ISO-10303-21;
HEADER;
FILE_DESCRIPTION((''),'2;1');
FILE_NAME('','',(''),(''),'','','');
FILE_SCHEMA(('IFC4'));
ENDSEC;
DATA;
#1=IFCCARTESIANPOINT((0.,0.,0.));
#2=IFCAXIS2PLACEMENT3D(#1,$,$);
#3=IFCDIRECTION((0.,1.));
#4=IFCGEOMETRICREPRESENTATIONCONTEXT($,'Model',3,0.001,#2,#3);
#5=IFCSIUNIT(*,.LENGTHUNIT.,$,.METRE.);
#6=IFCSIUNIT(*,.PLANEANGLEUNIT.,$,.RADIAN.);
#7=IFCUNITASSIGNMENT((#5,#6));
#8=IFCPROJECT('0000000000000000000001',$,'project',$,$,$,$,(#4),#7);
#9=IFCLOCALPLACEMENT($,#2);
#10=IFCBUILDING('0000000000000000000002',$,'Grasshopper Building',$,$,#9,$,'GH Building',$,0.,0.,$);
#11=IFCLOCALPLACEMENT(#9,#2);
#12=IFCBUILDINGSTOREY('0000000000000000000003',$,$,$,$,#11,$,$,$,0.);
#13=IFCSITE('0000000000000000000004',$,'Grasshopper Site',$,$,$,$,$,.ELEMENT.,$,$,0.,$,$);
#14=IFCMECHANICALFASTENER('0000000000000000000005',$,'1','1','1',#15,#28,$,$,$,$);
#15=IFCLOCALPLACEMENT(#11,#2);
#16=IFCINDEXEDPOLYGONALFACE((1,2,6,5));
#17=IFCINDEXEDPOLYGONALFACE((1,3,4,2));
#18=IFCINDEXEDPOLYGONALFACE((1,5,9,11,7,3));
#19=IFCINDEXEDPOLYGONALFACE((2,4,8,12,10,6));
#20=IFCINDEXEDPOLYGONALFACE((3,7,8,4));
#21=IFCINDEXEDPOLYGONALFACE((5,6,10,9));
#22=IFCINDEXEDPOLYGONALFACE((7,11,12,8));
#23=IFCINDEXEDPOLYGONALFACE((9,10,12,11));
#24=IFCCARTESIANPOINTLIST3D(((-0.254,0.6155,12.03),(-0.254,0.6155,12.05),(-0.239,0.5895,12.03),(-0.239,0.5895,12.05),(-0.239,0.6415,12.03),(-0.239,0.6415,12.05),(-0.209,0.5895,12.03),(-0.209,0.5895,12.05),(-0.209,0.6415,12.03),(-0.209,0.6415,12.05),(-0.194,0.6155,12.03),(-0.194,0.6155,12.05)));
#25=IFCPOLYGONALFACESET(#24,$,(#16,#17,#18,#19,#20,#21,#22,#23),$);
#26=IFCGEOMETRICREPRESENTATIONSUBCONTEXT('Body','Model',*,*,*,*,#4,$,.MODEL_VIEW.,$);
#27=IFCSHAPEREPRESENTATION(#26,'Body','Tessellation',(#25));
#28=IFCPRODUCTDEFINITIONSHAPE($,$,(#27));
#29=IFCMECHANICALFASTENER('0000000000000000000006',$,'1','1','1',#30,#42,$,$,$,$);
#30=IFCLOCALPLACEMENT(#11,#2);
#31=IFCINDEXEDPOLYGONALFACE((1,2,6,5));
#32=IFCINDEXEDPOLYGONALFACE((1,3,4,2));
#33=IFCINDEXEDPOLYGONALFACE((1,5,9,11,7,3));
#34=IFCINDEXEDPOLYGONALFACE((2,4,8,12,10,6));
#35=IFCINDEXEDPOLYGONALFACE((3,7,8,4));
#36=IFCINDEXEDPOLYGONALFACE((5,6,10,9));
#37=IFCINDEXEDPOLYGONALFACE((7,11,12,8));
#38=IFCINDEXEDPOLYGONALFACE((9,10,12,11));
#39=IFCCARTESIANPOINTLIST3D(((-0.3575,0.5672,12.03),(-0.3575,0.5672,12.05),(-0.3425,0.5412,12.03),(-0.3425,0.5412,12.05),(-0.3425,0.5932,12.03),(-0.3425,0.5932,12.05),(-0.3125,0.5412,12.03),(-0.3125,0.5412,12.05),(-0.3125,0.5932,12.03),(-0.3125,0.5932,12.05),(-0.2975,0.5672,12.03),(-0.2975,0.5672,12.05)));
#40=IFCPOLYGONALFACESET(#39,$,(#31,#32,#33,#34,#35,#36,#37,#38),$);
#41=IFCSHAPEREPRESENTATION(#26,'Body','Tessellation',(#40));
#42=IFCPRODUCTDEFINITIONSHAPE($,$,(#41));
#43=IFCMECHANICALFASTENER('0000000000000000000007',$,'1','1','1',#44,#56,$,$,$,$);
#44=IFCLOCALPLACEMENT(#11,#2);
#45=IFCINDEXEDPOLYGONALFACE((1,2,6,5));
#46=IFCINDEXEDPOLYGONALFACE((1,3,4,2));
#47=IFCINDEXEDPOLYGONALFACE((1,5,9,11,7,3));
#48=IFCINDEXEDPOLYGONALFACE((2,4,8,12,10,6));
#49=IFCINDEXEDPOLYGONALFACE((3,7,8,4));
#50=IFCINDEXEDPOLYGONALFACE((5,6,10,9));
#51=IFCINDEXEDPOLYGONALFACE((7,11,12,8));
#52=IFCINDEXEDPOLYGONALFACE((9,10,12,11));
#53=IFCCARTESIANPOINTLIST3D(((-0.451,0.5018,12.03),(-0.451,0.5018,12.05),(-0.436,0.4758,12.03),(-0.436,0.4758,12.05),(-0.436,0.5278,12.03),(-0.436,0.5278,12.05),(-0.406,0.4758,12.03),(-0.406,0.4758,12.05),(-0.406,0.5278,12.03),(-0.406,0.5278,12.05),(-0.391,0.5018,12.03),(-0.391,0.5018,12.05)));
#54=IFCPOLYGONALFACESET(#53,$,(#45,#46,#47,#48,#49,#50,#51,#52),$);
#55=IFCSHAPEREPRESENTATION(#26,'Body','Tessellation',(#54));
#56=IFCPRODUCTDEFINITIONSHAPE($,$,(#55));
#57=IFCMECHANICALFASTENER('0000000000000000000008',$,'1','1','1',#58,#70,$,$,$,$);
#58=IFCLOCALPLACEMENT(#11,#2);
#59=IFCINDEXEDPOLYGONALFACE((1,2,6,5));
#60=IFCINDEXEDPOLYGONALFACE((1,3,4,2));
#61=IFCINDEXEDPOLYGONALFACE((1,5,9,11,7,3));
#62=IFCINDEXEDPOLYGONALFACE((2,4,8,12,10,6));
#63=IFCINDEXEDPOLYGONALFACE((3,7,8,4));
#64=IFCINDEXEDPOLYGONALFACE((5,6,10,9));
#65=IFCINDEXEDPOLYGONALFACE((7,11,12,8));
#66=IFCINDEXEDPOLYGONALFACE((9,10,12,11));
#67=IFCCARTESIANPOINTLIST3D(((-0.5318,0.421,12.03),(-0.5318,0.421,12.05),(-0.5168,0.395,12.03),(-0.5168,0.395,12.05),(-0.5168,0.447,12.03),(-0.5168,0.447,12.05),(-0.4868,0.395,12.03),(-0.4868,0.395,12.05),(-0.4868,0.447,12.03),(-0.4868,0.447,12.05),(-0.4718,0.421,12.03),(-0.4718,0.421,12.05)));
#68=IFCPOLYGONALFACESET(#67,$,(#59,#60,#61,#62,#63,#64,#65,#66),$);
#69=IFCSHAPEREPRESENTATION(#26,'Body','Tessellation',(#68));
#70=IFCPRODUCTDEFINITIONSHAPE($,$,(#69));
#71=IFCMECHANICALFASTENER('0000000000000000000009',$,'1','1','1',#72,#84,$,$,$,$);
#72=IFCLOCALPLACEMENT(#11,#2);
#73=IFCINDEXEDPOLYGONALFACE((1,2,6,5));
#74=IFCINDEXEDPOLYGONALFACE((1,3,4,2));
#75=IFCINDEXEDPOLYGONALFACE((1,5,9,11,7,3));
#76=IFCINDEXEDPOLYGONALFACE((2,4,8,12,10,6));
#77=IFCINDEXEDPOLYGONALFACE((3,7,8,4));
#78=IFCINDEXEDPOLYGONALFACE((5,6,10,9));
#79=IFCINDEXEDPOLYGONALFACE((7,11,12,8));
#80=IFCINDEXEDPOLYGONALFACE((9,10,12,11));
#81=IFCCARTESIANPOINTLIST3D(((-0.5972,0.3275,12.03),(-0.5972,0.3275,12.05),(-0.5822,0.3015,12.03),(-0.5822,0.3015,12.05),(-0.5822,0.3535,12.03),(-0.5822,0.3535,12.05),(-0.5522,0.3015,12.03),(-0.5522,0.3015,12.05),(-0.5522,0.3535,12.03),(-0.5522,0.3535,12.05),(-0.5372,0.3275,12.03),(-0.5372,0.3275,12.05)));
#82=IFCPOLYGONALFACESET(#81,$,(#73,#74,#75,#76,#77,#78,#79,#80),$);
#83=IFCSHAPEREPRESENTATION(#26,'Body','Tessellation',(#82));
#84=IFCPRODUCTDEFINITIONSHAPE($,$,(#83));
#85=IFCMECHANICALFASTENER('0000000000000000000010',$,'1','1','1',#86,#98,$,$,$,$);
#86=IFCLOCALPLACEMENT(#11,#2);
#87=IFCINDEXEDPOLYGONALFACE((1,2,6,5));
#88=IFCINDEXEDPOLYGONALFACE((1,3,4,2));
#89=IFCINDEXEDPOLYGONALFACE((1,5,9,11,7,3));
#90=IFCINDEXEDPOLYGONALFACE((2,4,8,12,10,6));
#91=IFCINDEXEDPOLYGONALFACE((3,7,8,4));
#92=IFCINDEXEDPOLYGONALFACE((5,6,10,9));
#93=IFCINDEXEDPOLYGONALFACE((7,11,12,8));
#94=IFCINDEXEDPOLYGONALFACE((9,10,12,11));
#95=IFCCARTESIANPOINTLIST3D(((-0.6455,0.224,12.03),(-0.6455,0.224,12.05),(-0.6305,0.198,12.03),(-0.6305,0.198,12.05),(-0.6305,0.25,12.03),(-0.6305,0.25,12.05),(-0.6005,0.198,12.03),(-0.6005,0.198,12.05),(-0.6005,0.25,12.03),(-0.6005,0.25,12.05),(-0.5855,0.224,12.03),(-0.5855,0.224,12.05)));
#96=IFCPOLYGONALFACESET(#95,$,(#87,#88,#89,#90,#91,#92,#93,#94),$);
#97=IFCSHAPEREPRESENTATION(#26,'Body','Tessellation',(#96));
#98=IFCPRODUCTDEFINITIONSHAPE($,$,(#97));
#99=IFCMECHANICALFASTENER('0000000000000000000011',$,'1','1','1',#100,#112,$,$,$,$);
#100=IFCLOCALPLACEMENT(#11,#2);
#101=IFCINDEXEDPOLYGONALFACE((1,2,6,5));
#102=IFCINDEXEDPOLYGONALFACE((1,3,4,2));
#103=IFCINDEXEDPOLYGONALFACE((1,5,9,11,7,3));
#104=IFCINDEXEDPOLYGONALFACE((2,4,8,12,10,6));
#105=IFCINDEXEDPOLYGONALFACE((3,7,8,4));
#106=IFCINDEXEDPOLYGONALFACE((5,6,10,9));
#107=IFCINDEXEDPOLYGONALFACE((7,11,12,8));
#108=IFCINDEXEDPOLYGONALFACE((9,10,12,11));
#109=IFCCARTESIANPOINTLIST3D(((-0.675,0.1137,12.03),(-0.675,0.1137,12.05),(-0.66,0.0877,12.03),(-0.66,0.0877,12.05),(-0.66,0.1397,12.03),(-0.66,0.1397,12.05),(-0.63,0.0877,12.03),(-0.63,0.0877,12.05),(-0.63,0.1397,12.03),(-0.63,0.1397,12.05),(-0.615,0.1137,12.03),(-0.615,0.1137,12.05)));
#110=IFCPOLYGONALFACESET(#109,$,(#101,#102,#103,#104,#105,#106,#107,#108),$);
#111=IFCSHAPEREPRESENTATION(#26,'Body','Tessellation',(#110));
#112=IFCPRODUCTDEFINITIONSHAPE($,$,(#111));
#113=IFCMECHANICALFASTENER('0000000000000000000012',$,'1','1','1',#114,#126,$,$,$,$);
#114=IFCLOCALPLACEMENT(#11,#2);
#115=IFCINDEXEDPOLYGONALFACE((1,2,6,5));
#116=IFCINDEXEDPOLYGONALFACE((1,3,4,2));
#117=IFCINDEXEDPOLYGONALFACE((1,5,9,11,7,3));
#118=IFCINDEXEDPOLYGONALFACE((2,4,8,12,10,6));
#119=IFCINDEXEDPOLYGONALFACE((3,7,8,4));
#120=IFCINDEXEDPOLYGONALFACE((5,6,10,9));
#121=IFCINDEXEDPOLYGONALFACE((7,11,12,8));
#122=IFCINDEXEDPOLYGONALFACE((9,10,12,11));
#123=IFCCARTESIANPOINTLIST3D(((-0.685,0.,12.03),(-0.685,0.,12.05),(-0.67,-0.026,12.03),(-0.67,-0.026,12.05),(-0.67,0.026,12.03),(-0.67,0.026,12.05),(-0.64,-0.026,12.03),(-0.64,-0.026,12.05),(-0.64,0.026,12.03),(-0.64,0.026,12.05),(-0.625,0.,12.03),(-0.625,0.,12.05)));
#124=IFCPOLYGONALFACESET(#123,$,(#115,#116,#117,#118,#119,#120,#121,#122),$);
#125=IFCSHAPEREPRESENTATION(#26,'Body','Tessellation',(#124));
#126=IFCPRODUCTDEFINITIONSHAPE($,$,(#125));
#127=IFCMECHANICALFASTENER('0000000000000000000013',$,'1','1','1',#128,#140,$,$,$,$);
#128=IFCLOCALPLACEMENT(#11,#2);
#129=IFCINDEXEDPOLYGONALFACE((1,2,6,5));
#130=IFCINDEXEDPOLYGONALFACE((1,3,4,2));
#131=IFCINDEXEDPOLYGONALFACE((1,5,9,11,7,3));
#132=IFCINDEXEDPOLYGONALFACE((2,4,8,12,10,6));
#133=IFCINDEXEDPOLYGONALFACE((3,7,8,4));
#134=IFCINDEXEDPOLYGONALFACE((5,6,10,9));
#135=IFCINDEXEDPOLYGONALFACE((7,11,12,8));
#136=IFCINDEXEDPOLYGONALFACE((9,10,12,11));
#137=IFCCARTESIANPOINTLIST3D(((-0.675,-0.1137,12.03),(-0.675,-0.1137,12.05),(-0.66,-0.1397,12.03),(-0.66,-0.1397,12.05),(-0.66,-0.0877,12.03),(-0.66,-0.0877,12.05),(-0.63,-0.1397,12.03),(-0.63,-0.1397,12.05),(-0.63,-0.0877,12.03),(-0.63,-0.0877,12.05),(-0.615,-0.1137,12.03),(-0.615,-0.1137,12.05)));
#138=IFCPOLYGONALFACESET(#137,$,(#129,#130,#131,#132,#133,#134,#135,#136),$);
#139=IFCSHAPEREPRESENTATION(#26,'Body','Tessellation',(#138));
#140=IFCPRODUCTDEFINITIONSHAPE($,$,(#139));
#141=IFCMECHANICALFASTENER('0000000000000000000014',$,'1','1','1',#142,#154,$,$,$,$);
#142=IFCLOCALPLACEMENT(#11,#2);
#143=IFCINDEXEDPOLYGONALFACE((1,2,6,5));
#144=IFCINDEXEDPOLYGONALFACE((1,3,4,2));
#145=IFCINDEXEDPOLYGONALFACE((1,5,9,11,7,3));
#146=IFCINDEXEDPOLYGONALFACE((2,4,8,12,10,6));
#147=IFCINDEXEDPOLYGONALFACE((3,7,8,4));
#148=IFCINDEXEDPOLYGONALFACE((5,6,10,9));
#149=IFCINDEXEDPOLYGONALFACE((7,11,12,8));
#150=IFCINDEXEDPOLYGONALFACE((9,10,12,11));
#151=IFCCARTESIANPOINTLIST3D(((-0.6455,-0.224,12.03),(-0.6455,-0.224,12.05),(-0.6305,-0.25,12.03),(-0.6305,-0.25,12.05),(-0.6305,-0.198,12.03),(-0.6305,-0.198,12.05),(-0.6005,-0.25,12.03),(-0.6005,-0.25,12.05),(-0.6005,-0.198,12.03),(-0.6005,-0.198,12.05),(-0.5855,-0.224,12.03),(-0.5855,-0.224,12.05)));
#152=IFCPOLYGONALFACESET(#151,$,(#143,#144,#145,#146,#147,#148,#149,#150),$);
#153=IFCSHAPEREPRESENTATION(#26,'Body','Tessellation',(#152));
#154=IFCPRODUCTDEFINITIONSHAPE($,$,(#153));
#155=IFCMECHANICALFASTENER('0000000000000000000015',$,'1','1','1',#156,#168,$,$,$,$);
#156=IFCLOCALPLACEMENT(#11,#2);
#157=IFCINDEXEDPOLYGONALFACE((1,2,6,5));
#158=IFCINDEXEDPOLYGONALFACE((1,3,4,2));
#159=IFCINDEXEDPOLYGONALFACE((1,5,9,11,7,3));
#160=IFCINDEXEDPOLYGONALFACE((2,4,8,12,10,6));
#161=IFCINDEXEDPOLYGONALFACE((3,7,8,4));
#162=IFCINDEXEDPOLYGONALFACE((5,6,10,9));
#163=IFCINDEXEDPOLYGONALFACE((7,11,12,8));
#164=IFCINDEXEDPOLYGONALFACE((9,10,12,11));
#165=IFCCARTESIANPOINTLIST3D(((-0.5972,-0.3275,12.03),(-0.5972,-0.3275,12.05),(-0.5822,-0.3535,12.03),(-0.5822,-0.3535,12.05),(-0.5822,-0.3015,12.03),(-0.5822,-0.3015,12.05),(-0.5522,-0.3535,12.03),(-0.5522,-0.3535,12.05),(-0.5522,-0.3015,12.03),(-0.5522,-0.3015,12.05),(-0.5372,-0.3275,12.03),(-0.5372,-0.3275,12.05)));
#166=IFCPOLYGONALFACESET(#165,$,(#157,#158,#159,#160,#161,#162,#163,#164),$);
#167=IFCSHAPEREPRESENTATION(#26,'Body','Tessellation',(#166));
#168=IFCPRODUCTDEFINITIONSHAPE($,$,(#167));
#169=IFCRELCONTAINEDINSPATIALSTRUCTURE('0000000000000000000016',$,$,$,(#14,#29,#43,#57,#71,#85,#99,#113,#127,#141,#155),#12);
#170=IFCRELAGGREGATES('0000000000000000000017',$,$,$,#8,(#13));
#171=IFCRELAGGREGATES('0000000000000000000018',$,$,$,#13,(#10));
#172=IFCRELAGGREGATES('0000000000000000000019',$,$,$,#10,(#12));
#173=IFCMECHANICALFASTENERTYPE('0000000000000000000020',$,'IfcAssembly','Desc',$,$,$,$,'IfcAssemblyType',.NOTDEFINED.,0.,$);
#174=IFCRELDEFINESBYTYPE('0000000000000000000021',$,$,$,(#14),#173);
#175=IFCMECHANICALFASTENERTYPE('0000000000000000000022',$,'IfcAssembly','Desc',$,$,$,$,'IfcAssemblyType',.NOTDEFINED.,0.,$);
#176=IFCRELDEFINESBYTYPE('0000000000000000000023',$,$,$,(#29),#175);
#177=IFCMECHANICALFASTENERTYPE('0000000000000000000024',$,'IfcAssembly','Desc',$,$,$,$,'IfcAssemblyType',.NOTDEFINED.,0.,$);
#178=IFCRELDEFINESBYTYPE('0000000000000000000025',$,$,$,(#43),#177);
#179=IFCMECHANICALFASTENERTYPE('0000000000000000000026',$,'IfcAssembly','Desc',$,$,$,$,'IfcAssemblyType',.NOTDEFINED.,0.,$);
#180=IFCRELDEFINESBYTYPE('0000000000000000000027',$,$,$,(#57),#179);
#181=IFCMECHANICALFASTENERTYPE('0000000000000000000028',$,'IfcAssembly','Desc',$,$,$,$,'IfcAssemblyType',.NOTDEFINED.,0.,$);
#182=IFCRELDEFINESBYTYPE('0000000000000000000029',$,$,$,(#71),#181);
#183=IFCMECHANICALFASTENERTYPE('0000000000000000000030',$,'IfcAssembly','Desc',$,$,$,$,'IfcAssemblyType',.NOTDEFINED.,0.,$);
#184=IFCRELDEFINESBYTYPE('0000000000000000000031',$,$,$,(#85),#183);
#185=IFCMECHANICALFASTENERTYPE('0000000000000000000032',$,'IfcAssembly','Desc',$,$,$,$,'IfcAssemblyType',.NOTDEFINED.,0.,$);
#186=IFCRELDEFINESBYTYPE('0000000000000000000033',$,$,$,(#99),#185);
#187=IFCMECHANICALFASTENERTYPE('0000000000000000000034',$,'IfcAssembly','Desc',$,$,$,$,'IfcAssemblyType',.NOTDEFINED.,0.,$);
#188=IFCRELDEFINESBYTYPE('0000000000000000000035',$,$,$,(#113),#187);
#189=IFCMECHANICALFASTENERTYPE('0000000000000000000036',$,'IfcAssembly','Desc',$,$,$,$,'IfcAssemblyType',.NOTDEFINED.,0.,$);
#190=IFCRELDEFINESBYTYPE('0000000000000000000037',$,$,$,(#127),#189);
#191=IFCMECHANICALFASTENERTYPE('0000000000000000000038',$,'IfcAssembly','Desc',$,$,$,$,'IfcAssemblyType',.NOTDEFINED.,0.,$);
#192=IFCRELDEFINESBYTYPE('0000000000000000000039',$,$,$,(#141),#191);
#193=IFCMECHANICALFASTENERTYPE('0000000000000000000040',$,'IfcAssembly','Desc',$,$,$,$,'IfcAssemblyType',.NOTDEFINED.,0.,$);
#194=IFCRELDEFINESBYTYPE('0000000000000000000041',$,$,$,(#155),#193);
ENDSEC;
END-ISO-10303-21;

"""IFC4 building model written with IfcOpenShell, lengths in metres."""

from ifc_helpers import new_model, si_unit, direction, frame, origin, place, context, subcontext, project, spatial, indexed_curve, outline, extrude, source, transform, mapped, type_object, type_shapes, element, save


model = new_model("IFC4")

# Units and contexts
model_context = context("Model", 3, precision=0.001, world=origin(), true_north=direction((0.0, 1.0)))
body_context = subcontext(model_context, "Body", "Model", "MODEL_VIEW")
ifc_project = project(units=[si_unit("LENGTHUNIT", "METRE"), si_unit("PLANEANGLEUNIT", "RADIAN")], contexts=[model_context])

# Site, building, storey
site = spatial("IfcSite", under=ifc_project, Name="Grasshopper Site", CompositionType="ELEMENT", RefElevation=0.0)
building_placement = place(None, origin())
building = spatial("IfcBuilding", under=site, at=building_placement, Name="Grasshopper Building", LongName="GH Building", ElevationOfRefHeight=0.0, ElevationOfTerrain=0.0)
storey_placement = place(building_placement, origin())
storey = spatial("IfcBuildingStorey", under=building, at=storey_placement, Elevation=0.0)

# Mechanical fasteners
mechanical_fastener_type_1 = type_object("IfcMechanicalFastenerType", Name="IfcAssembly", Description="Desc", ElementType="IfcAssemblyType", NominalDiameter=0.0)
shared_shape_1 = source(origin(), body_context, "Body", "SweptSolid", [
    extrude(outline(indexed_curve([(0.03, 0.0), (0.015, 0.026), (-0.015, 0.026), (-0.03, 0.0), (-0.015, -0.026), (0.015, -0.026), (0.03, 0.0)])), frame((-0.224, 0.6155, 12.03)), (0.0, 0.0, 1.0), 0.02),
])
type_shapes(mechanical_fastener_type_1, [shared_shape_1])
mechanical_fastener_1_placement = place(storey_placement, origin())
element("IfcMechanicalFastener", 1, at=mechanical_fastener_1_placement, inside=storey, type_object=mechanical_fastener_type_1, Name="1", Description="1", ObjectType="1", context=body_context, shape_type="MappedRepresentation", body=[
    mapped(shared_shape_1, transform((0.0, 0.0, 0.0), scale=1.0)),
])
mechanical_fastener_type_2 = type_object("IfcMechanicalFastenerType", Name="IfcAssembly", Description="Desc", ElementType="IfcAssemblyType", NominalDiameter=0.0)
shared_shape_2 = source(origin(), body_context, "Body", "SweptSolid", [
    extrude(outline(indexed_curve([(0.03, 0.0), (0.015, 0.026), (-0.015, 0.026), (-0.03, 0.0), (-0.015, -0.026), (0.015, -0.026), (0.03, 0.0)])), frame((-0.3275, 0.5672, 12.03)), (0.0, 0.0, 1.0), 0.02),
])
type_shapes(mechanical_fastener_type_2, [shared_shape_2])
mechanical_fastener_2_placement = place(storey_placement, origin())
element("IfcMechanicalFastener", 2, at=mechanical_fastener_2_placement, inside=storey, type_object=mechanical_fastener_type_2, Name="1", Description="1", ObjectType="1", context=body_context, shape_type="MappedRepresentation", body=[
    mapped(shared_shape_2, transform((0.0, 0.0, 0.0), scale=1.0)),
])
mechanical_fastener_type_3 = type_object("IfcMechanicalFastenerType", Name="IfcAssembly", Description="Desc", ElementType="IfcAssemblyType", NominalDiameter=0.0)
shared_shape_3 = source(origin(), body_context, "Body", "SweptSolid", [
    extrude(outline(indexed_curve([(0.03, 0.0), (0.015, 0.026), (-0.015, 0.026), (-0.03, 0.0), (-0.015, -0.026), (0.015, -0.026), (0.03, 0.0)])), frame((-0.421, 0.5018, 12.03)), (0.0, 0.0, 1.0), 0.02),
])
type_shapes(mechanical_fastener_type_3, [shared_shape_3])
mechanical_fastener_3_placement = place(storey_placement, origin())
element("IfcMechanicalFastener", 3, at=mechanical_fastener_3_placement, inside=storey, type_object=mechanical_fastener_type_3, Name="1", Description="1", ObjectType="1", context=body_context, shape_type="MappedRepresentation", body=[
    mapped(shared_shape_3, transform((0.0, 0.0, 0.0), scale=1.0)),
])
mechanical_fastener_type_4 = type_object("IfcMechanicalFastenerType", Name="IfcAssembly", Description="Desc", ElementType="IfcAssemblyType", NominalDiameter=0.0)
shared_shape_4 = source(origin(), body_context, "Body", "SweptSolid", [
    extrude(outline(indexed_curve([(0.03, 0.0), (0.015, 0.026), (-0.015, 0.026), (-0.03, 0.0), (-0.015, -0.026), (0.015, -0.026), (0.03, 0.0)])), frame((-0.5018, 0.421, 12.03)), (0.0, 0.0, 1.0), 0.02),
])
type_shapes(mechanical_fastener_type_4, [shared_shape_4])
mechanical_fastener_4_placement = place(storey_placement, origin())
element("IfcMechanicalFastener", 4, at=mechanical_fastener_4_placement, inside=storey, type_object=mechanical_fastener_type_4, Name="1", Description="1", ObjectType="1", context=body_context, shape_type="MappedRepresentation", body=[
    mapped(shared_shape_4, transform((0.0, 0.0, 0.0), scale=1.0)),
])
mechanical_fastener_type_5 = type_object("IfcMechanicalFastenerType", Name="IfcAssembly", Description="Desc", ElementType="IfcAssemblyType", NominalDiameter=0.0)
shared_shape_5 = source(origin(), body_context, "Body", "SweptSolid", [
    extrude(outline(indexed_curve([(0.03, 0.0), (0.015, 0.026), (-0.015, 0.026), (-0.03, 0.0), (-0.015, -0.026), (0.015, -0.026), (0.03, 0.0)])), frame((-0.5672, 0.3275, 12.03)), (0.0, 0.0, 1.0), 0.02),
])
type_shapes(mechanical_fastener_type_5, [shared_shape_5])
mechanical_fastener_5_placement = place(storey_placement, origin())
element("IfcMechanicalFastener", 5, at=mechanical_fastener_5_placement, inside=storey, type_object=mechanical_fastener_type_5, Name="1", Description="1", ObjectType="1", context=body_context, shape_type="MappedRepresentation", body=[
    mapped(shared_shape_5, transform((0.0, 0.0, 0.0), scale=1.0)),
])
mechanical_fastener_type_6 = type_object("IfcMechanicalFastenerType", Name="IfcAssembly", Description="Desc", ElementType="IfcAssemblyType", NominalDiameter=0.0)
shared_shape_6 = source(origin(), body_context, "Body", "SweptSolid", [
    extrude(outline(indexed_curve([(0.03, 0.0), (0.015, 0.026), (-0.015, 0.026), (-0.03, 0.0), (-0.015, -0.026), (0.015, -0.026), (0.03, 0.0)])), frame((-0.6155, 0.224, 12.03)), (0.0, 0.0, 1.0), 0.02),
])
type_shapes(mechanical_fastener_type_6, [shared_shape_6])
mechanical_fastener_6_placement = place(storey_placement, origin())
element("IfcMechanicalFastener", 6, at=mechanical_fastener_6_placement, inside=storey, type_object=mechanical_fastener_type_6, Name="1", Description="1", ObjectType="1", context=body_context, shape_type="MappedRepresentation", body=[
    mapped(shared_shape_6, transform((0.0, 0.0, 0.0), scale=1.0)),
])
mechanical_fastener_type_7 = type_object("IfcMechanicalFastenerType", Name="IfcAssembly", Description="Desc", ElementType="IfcAssemblyType", NominalDiameter=0.0)
shared_shape_7 = source(origin(), body_context, "Body", "SweptSolid", [
    extrude(outline(indexed_curve([(0.03, 0.0), (0.015, 0.026), (-0.015, 0.026), (-0.03, 0.0), (-0.015, -0.026), (0.015, -0.026), (0.03, 0.0)])), frame((-0.645, 0.1137, 12.03)), (0.0, 0.0, 1.0), 0.02),
])
type_shapes(mechanical_fastener_type_7, [shared_shape_7])
mechanical_fastener_7_placement = place(storey_placement, origin())
element("IfcMechanicalFastener", 7, at=mechanical_fastener_7_placement, inside=storey, type_object=mechanical_fastener_type_7, Name="1", Description="1", ObjectType="1", context=body_context, shape_type="MappedRepresentation", body=[
    mapped(shared_shape_7, transform((0.0, 0.0, 0.0), scale=1.0)),
])
mechanical_fastener_type_8 = type_object("IfcMechanicalFastenerType", Name="IfcAssembly", Description="Desc", ElementType="IfcAssemblyType", NominalDiameter=0.0)
shared_shape_8 = source(origin(), body_context, "Body", "SweptSolid", [
    extrude(outline(indexed_curve([(0.03, 0.0), (0.015, 0.026), (-0.015, 0.026), (-0.03, 0.0), (-0.015, -0.026), (0.015, -0.026), (0.03, 0.0)])), frame((-0.655, 0.0, 12.03)), (0.0, 0.0, 1.0), 0.02),
])
type_shapes(mechanical_fastener_type_8, [shared_shape_8])
mechanical_fastener_8_placement = place(storey_placement, origin())
element("IfcMechanicalFastener", 8, at=mechanical_fastener_8_placement, inside=storey, type_object=mechanical_fastener_type_8, Name="1", Description="1", ObjectType="1", context=body_context, shape_type="MappedRepresentation", body=[
    mapped(shared_shape_8, transform((0.0, 0.0, 0.0), scale=1.0)),
])
mechanical_fastener_type_9 = type_object("IfcMechanicalFastenerType", Name="IfcAssembly", Description="Desc", ElementType="IfcAssemblyType", NominalDiameter=0.0)
shared_shape_9 = source(origin(), body_context, "Body", "SweptSolid", [
    extrude(outline(indexed_curve([(0.03, 0.0), (0.015, 0.026), (-0.015, 0.026), (-0.03, 0.0), (-0.015, -0.026), (0.015, -0.026), (0.03, 0.0)])), frame((-0.645, -0.1137, 12.03)), (0.0, 0.0, 1.0), 0.02),
])
type_shapes(mechanical_fastener_type_9, [shared_shape_9])
mechanical_fastener_9_placement = place(storey_placement, origin())
element("IfcMechanicalFastener", 9, at=mechanical_fastener_9_placement, inside=storey, type_object=mechanical_fastener_type_9, Name="1", Description="1", ObjectType="1", context=body_context, shape_type="MappedRepresentation", body=[
    mapped(shared_shape_9, transform((0.0, 0.0, 0.0), scale=1.0)),
])
mechanical_fastener_type_10 = type_object("IfcMechanicalFastenerType", Name="IfcAssembly", Description="Desc", ElementType="IfcAssemblyType", NominalDiameter=0.0)
shared_shape_10 = source(origin(), body_context, "Body", "SweptSolid", [
    extrude(outline(indexed_curve([(0.03, 0.0), (0.015, 0.026), (-0.015, 0.026), (-0.03, 0.0), (-0.015, -0.026), (0.015, -0.026), (0.03, 0.0)])), frame((-0.6155, -0.224, 12.03)), (0.0, 0.0, 1.0), 0.02),
])
type_shapes(mechanical_fastener_type_10, [shared_shape_10])
mechanical_fastener_10_placement = place(storey_placement, origin())
element("IfcMechanicalFastener", 10, at=mechanical_fastener_10_placement, inside=storey, type_object=mechanical_fastener_type_10, Name="1", Description="1", ObjectType="1", context=body_context, shape_type="MappedRepresentation", body=[
    mapped(shared_shape_10, transform((0.0, 0.0, 0.0), scale=1.0)),
])
mechanical_fastener_type_11 = type_object("IfcMechanicalFastenerType", Name="IfcAssembly", Description="Desc", ElementType="IfcAssemblyType", NominalDiameter=0.0)
shared_shape_11 = source(origin(), body_context, "Body", "SweptSolid", [
    extrude(outline(indexed_curve([(0.03, 0.0), (0.015, 0.026), (-0.015, 0.026), (-0.03, 0.0), (-0.015, -0.026), (0.015, -0.026), (0.03, 0.0)])), frame((-0.5672, -0.3275, 12.03)), (0.0, 0.0, 1.0), 0.02),
])
type_shapes(mechanical_fastener_type_11, [shared_shape_11])
mechanical_fastener_11_placement = place(storey_placement, origin())
element("IfcMechanicalFastener", 11, at=mechanical_fastener_11_placement, inside=storey, type_object=mechanical_fastener_type_11, Name="1", Description="1", ObjectType="1", context=body_context, shape_type="MappedRepresentation", body=[
    mapped(shared_shape_11, transform((0.0, 0.0, 0.0), scale=1.0)),
])

save(model, "model.ifc")
